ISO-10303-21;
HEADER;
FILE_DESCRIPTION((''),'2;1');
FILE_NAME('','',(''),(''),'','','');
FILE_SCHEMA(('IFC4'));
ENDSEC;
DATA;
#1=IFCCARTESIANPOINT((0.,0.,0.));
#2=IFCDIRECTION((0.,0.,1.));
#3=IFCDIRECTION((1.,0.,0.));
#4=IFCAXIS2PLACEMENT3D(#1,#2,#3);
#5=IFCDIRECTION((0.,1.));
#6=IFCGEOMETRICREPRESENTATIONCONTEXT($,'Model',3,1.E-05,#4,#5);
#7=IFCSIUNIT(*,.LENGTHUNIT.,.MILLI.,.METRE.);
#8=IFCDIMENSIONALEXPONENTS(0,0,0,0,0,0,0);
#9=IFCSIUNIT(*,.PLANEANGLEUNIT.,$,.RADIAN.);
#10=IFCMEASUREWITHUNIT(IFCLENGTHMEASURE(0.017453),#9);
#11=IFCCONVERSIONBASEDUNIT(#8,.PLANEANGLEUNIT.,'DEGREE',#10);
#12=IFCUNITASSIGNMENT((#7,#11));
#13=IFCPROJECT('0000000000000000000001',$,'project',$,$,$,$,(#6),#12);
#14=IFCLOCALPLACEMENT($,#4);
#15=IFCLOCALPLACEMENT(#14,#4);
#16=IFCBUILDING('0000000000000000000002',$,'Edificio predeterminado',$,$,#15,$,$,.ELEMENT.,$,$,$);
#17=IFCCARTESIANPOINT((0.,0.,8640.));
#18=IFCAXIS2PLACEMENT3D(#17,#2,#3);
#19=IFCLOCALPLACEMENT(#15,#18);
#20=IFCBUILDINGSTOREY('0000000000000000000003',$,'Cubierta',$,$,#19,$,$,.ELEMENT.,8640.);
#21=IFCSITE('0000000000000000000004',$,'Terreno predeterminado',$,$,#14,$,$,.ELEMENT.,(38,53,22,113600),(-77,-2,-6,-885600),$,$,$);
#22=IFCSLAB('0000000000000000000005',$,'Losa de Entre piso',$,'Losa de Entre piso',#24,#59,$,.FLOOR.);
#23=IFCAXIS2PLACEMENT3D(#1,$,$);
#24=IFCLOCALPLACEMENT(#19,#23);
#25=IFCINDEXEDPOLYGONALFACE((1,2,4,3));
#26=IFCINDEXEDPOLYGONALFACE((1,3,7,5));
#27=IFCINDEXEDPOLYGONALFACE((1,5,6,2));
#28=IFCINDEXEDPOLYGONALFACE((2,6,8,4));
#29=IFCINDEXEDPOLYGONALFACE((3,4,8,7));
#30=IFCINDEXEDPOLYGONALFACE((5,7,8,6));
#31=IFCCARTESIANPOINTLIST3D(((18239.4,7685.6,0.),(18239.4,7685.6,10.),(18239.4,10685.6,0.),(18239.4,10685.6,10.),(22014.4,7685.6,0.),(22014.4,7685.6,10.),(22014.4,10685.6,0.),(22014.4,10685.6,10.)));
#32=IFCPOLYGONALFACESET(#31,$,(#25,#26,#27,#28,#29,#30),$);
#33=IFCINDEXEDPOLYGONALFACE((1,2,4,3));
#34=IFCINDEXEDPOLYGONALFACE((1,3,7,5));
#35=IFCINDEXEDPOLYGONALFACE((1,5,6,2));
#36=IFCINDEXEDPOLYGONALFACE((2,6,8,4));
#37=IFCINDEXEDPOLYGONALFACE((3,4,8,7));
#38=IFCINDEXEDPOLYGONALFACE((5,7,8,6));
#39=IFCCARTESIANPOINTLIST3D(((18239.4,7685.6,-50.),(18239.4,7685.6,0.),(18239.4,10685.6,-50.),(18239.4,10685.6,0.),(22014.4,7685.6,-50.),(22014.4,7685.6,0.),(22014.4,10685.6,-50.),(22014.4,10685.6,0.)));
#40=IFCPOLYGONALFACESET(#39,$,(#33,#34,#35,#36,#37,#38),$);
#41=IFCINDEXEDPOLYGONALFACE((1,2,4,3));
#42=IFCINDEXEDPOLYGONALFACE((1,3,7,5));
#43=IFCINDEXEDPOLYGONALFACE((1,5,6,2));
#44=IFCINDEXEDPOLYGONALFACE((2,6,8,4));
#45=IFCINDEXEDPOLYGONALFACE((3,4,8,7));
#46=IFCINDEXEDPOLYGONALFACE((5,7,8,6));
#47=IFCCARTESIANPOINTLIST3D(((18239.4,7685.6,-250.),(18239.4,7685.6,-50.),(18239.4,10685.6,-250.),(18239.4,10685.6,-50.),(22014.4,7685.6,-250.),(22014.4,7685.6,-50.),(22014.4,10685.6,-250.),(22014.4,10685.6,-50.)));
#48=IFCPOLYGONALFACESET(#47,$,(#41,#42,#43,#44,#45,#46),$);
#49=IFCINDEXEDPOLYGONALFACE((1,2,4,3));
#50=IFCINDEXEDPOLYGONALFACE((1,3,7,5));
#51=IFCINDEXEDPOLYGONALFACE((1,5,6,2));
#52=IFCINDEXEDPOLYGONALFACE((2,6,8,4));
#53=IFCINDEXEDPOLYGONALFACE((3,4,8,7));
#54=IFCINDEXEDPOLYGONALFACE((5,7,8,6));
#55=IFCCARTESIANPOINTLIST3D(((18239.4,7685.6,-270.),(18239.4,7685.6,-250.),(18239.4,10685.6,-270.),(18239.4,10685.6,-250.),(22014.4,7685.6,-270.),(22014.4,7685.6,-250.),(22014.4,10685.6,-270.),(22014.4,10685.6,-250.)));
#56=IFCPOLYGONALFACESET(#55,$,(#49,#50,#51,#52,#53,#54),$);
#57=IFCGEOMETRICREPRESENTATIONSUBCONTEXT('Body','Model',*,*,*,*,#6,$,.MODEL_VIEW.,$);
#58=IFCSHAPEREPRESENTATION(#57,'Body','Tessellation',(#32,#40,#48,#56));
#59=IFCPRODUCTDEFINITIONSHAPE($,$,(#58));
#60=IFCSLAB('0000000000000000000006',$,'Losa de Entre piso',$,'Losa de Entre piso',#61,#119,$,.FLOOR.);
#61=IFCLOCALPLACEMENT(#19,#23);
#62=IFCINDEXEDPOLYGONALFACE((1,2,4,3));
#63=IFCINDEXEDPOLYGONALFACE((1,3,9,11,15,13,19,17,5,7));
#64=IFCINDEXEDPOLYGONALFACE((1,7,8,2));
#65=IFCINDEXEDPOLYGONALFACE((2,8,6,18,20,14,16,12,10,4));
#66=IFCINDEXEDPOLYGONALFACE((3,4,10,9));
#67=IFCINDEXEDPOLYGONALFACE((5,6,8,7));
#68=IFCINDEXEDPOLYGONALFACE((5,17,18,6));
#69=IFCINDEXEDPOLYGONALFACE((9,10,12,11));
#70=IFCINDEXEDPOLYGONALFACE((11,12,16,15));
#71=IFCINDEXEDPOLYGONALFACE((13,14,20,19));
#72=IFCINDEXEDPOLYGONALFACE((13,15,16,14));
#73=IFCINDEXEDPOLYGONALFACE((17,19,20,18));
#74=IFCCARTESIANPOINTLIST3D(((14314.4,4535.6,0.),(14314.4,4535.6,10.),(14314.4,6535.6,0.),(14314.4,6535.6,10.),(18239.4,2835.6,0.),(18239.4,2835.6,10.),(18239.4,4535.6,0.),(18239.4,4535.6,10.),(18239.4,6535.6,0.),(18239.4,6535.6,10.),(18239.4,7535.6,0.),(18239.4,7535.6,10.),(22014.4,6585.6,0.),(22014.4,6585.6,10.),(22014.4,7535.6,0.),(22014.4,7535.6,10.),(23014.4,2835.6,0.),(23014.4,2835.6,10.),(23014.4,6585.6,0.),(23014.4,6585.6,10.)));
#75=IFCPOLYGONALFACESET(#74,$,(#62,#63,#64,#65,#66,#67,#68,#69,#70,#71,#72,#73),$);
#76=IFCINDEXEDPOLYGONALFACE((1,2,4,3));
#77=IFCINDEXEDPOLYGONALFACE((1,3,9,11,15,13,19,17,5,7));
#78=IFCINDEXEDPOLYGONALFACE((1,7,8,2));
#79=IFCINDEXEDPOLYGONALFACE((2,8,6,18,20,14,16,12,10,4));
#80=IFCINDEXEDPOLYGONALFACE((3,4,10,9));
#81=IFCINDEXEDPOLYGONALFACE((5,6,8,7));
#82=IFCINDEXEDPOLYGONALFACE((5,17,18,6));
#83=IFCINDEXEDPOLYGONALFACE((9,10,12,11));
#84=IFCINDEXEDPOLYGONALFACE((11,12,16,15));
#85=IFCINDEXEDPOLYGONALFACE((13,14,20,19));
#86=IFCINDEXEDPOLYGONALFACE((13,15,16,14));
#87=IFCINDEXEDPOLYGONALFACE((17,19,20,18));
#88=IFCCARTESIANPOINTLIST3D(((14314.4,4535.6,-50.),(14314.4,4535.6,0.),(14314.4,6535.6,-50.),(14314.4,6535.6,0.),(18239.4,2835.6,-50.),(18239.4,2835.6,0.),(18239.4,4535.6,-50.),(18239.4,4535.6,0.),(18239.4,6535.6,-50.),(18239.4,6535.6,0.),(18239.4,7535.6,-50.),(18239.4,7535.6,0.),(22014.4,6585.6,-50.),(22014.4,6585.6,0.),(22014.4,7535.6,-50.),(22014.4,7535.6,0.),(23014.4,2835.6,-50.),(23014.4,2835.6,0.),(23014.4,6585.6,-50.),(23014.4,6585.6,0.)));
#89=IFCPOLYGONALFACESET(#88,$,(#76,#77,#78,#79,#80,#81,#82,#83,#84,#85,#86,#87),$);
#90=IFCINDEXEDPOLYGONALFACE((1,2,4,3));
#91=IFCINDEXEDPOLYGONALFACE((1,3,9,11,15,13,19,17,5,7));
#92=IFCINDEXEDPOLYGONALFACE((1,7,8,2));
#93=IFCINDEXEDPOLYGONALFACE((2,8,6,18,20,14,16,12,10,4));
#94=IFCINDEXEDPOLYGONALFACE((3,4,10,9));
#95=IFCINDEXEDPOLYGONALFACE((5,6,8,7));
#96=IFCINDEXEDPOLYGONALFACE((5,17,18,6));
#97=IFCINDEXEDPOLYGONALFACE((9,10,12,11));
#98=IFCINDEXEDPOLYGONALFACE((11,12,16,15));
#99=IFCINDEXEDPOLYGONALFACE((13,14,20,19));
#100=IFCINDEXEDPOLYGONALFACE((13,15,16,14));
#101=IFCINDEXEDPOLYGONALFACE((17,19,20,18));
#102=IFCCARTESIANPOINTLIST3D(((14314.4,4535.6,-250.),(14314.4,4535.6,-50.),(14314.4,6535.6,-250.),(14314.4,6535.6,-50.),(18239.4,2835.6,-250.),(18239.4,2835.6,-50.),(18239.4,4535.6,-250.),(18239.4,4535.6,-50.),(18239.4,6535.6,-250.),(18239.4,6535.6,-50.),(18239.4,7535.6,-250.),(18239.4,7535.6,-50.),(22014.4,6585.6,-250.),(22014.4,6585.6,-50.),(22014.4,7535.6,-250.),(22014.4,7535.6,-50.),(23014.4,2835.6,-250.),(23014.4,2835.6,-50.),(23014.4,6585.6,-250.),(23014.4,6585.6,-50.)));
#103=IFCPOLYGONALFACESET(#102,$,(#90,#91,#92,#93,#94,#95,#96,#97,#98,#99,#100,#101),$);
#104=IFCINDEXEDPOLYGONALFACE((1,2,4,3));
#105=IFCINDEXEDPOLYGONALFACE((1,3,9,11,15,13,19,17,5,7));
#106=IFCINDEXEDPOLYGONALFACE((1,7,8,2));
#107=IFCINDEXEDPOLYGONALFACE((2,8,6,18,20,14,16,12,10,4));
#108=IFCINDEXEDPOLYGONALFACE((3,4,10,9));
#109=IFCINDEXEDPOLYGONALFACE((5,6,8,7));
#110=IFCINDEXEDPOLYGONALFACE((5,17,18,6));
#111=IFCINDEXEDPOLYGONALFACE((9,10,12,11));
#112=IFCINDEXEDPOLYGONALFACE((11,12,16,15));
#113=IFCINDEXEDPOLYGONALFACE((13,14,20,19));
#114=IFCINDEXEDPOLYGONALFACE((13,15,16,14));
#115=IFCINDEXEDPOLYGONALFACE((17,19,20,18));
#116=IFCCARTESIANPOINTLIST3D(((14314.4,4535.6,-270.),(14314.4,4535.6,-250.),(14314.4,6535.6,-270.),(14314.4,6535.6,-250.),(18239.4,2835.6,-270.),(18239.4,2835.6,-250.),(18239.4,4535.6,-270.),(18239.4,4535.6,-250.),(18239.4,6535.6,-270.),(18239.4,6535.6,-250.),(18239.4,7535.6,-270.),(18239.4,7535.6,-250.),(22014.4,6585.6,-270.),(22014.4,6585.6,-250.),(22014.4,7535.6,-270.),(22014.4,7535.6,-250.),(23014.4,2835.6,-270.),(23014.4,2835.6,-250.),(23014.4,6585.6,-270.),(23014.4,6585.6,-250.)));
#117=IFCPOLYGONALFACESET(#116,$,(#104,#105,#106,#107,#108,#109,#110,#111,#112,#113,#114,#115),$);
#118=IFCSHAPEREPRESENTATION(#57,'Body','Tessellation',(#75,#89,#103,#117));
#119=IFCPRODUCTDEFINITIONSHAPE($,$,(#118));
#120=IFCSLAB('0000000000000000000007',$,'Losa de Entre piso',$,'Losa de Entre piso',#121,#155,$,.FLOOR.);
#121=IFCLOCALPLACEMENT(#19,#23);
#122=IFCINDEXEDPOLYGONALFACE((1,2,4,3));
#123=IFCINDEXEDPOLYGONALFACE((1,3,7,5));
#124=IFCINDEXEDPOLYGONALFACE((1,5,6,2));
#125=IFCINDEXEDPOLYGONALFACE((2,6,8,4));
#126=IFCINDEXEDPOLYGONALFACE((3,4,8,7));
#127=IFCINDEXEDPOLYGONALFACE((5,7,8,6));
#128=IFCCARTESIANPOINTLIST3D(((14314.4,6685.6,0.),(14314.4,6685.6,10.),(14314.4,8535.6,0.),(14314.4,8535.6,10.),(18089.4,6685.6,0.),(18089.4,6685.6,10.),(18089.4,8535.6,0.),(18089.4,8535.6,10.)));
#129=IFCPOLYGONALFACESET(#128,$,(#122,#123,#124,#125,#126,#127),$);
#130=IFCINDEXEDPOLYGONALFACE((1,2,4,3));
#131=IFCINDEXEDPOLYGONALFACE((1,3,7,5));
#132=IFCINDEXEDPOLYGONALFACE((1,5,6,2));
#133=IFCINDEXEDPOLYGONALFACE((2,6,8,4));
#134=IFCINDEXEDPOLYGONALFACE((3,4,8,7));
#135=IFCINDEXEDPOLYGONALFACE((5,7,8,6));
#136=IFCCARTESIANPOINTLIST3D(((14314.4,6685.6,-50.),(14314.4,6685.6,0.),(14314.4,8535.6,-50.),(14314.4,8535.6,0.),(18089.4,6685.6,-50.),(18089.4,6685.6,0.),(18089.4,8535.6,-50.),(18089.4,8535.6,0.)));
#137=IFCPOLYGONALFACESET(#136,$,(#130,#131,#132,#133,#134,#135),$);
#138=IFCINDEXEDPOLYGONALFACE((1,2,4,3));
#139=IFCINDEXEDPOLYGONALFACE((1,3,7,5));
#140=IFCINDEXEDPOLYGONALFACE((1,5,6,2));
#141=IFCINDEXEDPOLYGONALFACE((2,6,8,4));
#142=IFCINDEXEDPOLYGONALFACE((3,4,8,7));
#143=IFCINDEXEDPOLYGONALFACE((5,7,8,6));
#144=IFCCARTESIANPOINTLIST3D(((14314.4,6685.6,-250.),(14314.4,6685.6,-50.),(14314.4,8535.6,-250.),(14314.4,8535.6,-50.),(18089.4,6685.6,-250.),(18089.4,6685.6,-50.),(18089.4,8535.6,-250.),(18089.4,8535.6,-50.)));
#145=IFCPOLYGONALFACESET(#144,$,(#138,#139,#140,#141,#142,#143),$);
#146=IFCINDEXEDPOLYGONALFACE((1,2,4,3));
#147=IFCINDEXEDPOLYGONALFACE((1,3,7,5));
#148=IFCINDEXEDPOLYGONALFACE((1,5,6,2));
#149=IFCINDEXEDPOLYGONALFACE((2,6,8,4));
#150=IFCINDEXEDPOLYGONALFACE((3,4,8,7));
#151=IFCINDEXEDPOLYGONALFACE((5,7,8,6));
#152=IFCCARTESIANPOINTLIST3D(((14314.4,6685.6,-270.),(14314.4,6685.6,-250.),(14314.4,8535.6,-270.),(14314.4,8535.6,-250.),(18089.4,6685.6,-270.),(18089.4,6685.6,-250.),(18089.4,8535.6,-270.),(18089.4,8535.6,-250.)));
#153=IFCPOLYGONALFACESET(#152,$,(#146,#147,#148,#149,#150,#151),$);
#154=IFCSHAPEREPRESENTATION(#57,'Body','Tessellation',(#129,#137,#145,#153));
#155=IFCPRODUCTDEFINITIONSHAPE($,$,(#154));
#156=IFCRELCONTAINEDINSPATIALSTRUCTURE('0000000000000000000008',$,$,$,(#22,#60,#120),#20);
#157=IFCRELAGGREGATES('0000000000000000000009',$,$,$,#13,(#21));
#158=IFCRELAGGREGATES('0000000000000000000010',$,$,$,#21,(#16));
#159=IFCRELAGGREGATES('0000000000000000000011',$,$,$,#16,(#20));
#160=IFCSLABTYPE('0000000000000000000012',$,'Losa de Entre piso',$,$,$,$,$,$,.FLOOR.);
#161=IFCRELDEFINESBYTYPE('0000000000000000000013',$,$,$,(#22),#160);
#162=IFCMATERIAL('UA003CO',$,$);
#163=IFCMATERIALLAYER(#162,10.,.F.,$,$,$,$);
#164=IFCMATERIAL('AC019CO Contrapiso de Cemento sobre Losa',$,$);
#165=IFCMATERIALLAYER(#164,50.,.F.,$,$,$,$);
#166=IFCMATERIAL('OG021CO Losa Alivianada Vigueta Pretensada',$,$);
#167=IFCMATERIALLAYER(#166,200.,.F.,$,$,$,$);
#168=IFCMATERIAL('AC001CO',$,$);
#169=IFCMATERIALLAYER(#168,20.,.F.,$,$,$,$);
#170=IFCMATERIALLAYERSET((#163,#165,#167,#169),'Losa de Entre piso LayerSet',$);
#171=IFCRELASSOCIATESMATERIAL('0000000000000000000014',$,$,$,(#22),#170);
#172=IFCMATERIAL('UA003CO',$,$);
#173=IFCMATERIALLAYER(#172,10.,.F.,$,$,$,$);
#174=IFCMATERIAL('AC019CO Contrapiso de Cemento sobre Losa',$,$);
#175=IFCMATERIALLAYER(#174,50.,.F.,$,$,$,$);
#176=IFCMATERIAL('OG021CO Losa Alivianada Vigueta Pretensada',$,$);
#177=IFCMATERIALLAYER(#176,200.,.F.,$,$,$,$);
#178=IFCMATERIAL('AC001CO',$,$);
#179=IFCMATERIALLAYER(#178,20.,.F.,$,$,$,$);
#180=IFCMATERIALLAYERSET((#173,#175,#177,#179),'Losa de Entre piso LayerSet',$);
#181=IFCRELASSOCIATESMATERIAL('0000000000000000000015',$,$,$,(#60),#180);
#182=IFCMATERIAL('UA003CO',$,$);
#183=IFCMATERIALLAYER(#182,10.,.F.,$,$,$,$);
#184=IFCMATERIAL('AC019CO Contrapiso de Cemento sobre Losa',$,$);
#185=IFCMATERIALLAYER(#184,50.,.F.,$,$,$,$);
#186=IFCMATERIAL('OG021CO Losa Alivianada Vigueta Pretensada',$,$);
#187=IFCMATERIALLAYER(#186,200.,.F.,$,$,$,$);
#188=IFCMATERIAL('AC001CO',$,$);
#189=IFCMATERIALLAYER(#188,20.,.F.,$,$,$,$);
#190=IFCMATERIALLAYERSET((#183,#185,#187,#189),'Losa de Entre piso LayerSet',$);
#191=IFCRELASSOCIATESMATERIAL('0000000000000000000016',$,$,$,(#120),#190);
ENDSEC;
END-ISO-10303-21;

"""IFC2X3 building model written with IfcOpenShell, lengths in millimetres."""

from ifc_helpers import new_model, entity, si_unit, converted_unit, direction, frame, origin_with_axes, place, context, subcontext, project, spatial, polyline, outline, extrude, material, layer, layer_set, layer_usage, type_object, element, save


model = new_model("IFC2X3")

# Units and contexts
model_context = context("Model", 3, precision=1e-05, world=origin_with_axes(), true_north=direction((0.0, 1.0)))
body_context = subcontext(model_context, "Body", "Model", "MODEL_VIEW")
ifc_project = project(units=[si_unit("LENGTHUNIT", "METRE", prefix="MILLI"), converted_unit("PLANEANGLEUNIT", "DEGREE", entity("IfcLengthMeasure", 0.017453), si_unit("PLANEANGLEUNIT", "RADIAN"), dimensions=[0, 0, 0, 0, 0, 0, 0])], contexts=[model_context])

# Site, building, storey
site_placement = place(None, origin_with_axes())
site = spatial("IfcSite", under=ifc_project, at=site_placement, Name="Terreno predeterminado", CompositionType="ELEMENT", RefLatitude=(38, 53, 22, 113600), RefLongitude=(-77, -2, -6, -885600))
building_placement = place(site_placement, origin_with_axes())
building = spatial("IfcBuilding", under=site, at=building_placement, Name="Edificio predeterminado", CompositionType="ELEMENT")
storey_placement = place(building_placement, frame((0.0, 0.0, 8640.0), z_axis=(0.0, 0.0, 1.0), x_axis=(1.0, 0.0, 0.0)))
storey = spatial("IfcBuildingStorey", under=building, at=storey_placement, Name="Cubierta", CompositionType="ELEMENT", Elevation=8640.0)

# Slabs
ifc_material_1 = material(Name="UA003CO")
ifc_layer_1 = layer(ifc_material_1, 10.0, ventilated=False)
ifc_material_2 = material(Name="AC019CO Contrapiso de Cemento sobre Losa")
ifc_layer_2 = layer(ifc_material_2, 50.0, ventilated=False)
ifc_material_3 = material(Name="OG021CO Losa Alivianada Vigueta Pretensada")
ifc_layer_3 = layer(ifc_material_3, 200.0, ventilated=False)
ifc_material_4 = material(Name="AC001CO")
ifc_layer_4 = layer(ifc_material_4, 20.0, ventilated=False)
ifc_layer_set_1 = layer_set([ifc_layer_1, ifc_layer_2, ifc_layer_3, ifc_layer_4], Name="Losa de Entre piso LayerSet")
ifc_layer_usage_1 = layer_usage(ifc_layer_set_1, "AXIS3", "NEGATIVE", 0.0)
slab_type = type_object("IfcSlabType", Name="Losa de Entre piso", PredefinedType="FLOOR")
slab_1_placement = place(storey_placement, frame((0.0, 0.0, -8640.0), z_axis=(0.0, 0.0, 1.0), x_axis=(1.0, 0.0, 0.0)))
element("IfcSlab", 1, at=slab_1_placement, inside=storey, type_object=slab_type, material=ifc_layer_usage_1, Name="Losa de Entre piso", ObjectType="Losa de Entre piso", PredefinedType="FLOOR", context=body_context, shape_type="SweptSolid", body=[
    extrude(outline(polyline([(0.0, 3000.0), (3775.0, 3000.0), (3775.0, 0.0), (0.0, 0.0), (0.0, 3000.0)])), frame((22014.4, 7685.6, 8640.0), z_axis=(0.0, 0.0, -1.0), x_axis=(-1.0, 0.0, 0.0)), (0.0, 0.0, -1.0), 10.0),
    extrude(outline(polyline([(0.0, 3000.0), (3775.0, 3000.0), (3775.0, 0.0), (0.0, 0.0), (0.0, 3000.0)])), frame((22014.4, 7685.6, 8590.0), z_axis=(0.0, 0.0, -1.0), x_axis=(-1.0, 0.0, 0.0)), (0.0, 0.0, -1.0), 50.0),
    extrude(outline(polyline([(0.0, 3000.0), (3775.0, 3000.0), (3775.0, 0.0), (0.0, 0.0), (0.0, 3000.0)])), frame((22014.4, 7685.6, 8390.0), z_axis=(0.0, 0.0, -1.0), x_axis=(-1.0, 0.0, 0.0)), (0.0, 0.0, -1.0), 200.0),
    extrude(outline(polyline([(0.0, 3000.0), (3775.0, 3000.0), (3775.0, 0.0), (0.0, 0.0), (0.0, 3000.0)])), frame((22014.4, 7685.6, 8370.0), z_axis=(0.0, 0.0, -1.0), x_axis=(-1.0, 0.0, 0.0)), (0.0, 0.0, -1.0), 20.0),
])
ifc_material_5 = material(Name="UA003CO")
ifc_layer_5 = layer(ifc_material_5, 10.0, ventilated=False)
ifc_material_6 = material(Name="AC019CO Contrapiso de Cemento sobre Losa")
ifc_layer_6 = layer(ifc_material_6, 50.0, ventilated=False)
ifc_material_7 = material(Name="OG021CO Losa Alivianada Vigueta Pretensada")
ifc_layer_7 = layer(ifc_material_7, 200.0, ventilated=False)
ifc_material_8 = material(Name="AC001CO")
ifc_layer_8 = layer(ifc_material_8, 20.0, ventilated=False)
ifc_layer_set_2 = layer_set([ifc_layer_5, ifc_layer_6, ifc_layer_7, ifc_layer_8], Name="Losa de Entre piso LayerSet")
ifc_layer_usage_2 = layer_usage(ifc_layer_set_2, "AXIS3", "NEGATIVE", 0.0)
slab_2_placement = place(storey_placement, frame((0.0, 0.0, -8640.0), z_axis=(0.0, 0.0, 1.0), x_axis=(1.0, 0.0, 0.0)))
element("IfcSlab", 2, at=slab_2_placement, inside=storey, material=ifc_layer_usage_2, Name="Losa de Entre piso", ObjectType="Losa de Entre piso", PredefinedType="FLOOR", context=body_context, shape_type="SweptSolid", body=[
    extrude(outline(polyline([(0.0, 1000.0), (-3925.0, 1000.0), (-3925.0, 3000.0), (0.0, 3000.0), (0.0, 4700.0), (4775.0, 4700.0), (4775.0, 950.0), (3775.0, 950.0), (3775.0, 0.0), (0.0, 0.0), (0.0, 1000.0)])), frame((18239.4, 7535.6, 8640.0), z_axis=(0.0, 0.0, -1.0), x_axis=(1.0, 0.0, 0.0)), (0.0, 0.0, -1.0), 10.0),
    extrude(outline(polyline([(0.0, 1000.0), (-3925.0, 1000.0), (-3925.0, 3000.0), (0.0, 3000.0), (0.0, 4700.0), (4775.0, 4700.0), (4775.0, 950.0), (3775.0, 950.0), (3775.0, 0.0), (0.0, 0.0), (0.0, 1000.0)])), frame((18239.4, 7535.6, 8590.0), z_axis=(0.0, 0.0, -1.0), x_axis=(1.0, 0.0, 0.0)), (0.0, 0.0, -1.0), 50.0),
    extrude(outline(polyline([(0.0, 1000.0), (-3925.0, 1000.0), (-3925.0, 3000.0), (0.0, 3000.0), (0.0, 4700.0), (4775.0, 4700.0), (4775.0, 950.0), (3775.0, 950.0), (3775.0, 0.0), (0.0, 0.0), (0.0, 1000.0)])), frame((18239.4, 7535.6, 8390.0), z_axis=(0.0, 0.0, -1.0), x_axis=(1.0, 0.0, 0.0)), (0.0, 0.0, -1.0), 200.0),
    extrude(outline(polyline([(0.0, 1000.0), (-3925.0, 1000.0), (-3925.0, 3000.0), (0.0, 3000.0), (0.0, 4700.0), (4775.0, 4700.0), (4775.0, 950.0), (3775.0, 950.0), (3775.0, 0.0), (0.0, 0.0), (0.0, 1000.0)])), frame((18239.4, 7535.6, 8370.0), z_axis=(0.0, 0.0, -1.0), x_axis=(1.0, 0.0, 0.0)), (0.0, 0.0, -1.0), 20.0),
])
ifc_material_9 = material(Name="UA003CO")
ifc_layer_9 = layer(ifc_material_9, 10.0, ventilated=False)
ifc_material_10 = material(Name="AC019CO Contrapiso de Cemento sobre Losa")
ifc_layer_10 = layer(ifc_material_10, 50.0, ventilated=False)
ifc_material_11 = material(Name="OG021CO Losa Alivianada Vigueta Pretensada")
ifc_layer_11 = layer(ifc_material_11, 200.0, ventilated=False)
ifc_material_12 = material(Name="AC001CO")
ifc_layer_12 = layer(ifc_material_12, 20.0, ventilated=False)
ifc_layer_set_3 = layer_set([ifc_layer_9, ifc_layer_10, ifc_layer_11, ifc_layer_12], Name="Losa de Entre piso LayerSet")
ifc_layer_usage_3 = layer_usage(ifc_layer_set_3, "AXIS3", "NEGATIVE", 0.0)
slab_3_placement = place(storey_placement, frame((0.0, 0.0, -8640.0), z_axis=(0.0, 0.0, 1.0), x_axis=(1.0, 0.0, 0.0)))
element("IfcSlab", 3, at=slab_3_placement, inside=storey, material=ifc_layer_usage_3, Name="Losa de Entre piso", ObjectType="Losa de Entre piso", PredefinedType="FLOOR", context=body_context, shape_type="SweptSolid", body=[
    extrude(outline(polyline([(0.0, 1850.0), (3775.0, 1850.0), (3775.0, 0.0), (0.0, 0.0), (0.0, 1850.0)])), frame((18089.4, 6685.6, 8640.0), z_axis=(0.0, 0.0, -1.0), x_axis=(-1.0, 0.0, 0.0)), (0.0, 0.0, -1.0), 10.0),
    extrude(outline(polyline([(0.0, 1850.0), (3775.0, 1850.0), (3775.0, 0.0), (0.0, 0.0), (0.0, 1850.0)])), frame((18089.4, 6685.6, 8590.0), z_axis=(0.0, 0.0, -1.0), x_axis=(-1.0, 0.0, 0.0)), (0.0, 0.0, -1.0), 50.0),
    extrude(outline(polyline([(0.0, 1850.0), (3775.0, 1850.0), (3775.0, 0.0), (0.0, 0.0), (0.0, 1850.0)])), frame((18089.4, 6685.6, 8390.0), z_axis=(0.0, 0.0, -1.0), x_axis=(-1.0, 0.0, 0.0)), (0.0, 0.0, -1.0), 200.0),
    extrude(outline(polyline([(0.0, 1850.0), (3775.0, 1850.0), (3775.0, 0.0), (0.0, 0.0), (0.0, 1850.0)])), frame((18089.4, 6685.6, 8370.0), z_axis=(0.0, 0.0, -1.0), x_axis=(-1.0, 0.0, 0.0)), (0.0, 0.0, -1.0), 20.0),
])

save(model, "model.ifc")
